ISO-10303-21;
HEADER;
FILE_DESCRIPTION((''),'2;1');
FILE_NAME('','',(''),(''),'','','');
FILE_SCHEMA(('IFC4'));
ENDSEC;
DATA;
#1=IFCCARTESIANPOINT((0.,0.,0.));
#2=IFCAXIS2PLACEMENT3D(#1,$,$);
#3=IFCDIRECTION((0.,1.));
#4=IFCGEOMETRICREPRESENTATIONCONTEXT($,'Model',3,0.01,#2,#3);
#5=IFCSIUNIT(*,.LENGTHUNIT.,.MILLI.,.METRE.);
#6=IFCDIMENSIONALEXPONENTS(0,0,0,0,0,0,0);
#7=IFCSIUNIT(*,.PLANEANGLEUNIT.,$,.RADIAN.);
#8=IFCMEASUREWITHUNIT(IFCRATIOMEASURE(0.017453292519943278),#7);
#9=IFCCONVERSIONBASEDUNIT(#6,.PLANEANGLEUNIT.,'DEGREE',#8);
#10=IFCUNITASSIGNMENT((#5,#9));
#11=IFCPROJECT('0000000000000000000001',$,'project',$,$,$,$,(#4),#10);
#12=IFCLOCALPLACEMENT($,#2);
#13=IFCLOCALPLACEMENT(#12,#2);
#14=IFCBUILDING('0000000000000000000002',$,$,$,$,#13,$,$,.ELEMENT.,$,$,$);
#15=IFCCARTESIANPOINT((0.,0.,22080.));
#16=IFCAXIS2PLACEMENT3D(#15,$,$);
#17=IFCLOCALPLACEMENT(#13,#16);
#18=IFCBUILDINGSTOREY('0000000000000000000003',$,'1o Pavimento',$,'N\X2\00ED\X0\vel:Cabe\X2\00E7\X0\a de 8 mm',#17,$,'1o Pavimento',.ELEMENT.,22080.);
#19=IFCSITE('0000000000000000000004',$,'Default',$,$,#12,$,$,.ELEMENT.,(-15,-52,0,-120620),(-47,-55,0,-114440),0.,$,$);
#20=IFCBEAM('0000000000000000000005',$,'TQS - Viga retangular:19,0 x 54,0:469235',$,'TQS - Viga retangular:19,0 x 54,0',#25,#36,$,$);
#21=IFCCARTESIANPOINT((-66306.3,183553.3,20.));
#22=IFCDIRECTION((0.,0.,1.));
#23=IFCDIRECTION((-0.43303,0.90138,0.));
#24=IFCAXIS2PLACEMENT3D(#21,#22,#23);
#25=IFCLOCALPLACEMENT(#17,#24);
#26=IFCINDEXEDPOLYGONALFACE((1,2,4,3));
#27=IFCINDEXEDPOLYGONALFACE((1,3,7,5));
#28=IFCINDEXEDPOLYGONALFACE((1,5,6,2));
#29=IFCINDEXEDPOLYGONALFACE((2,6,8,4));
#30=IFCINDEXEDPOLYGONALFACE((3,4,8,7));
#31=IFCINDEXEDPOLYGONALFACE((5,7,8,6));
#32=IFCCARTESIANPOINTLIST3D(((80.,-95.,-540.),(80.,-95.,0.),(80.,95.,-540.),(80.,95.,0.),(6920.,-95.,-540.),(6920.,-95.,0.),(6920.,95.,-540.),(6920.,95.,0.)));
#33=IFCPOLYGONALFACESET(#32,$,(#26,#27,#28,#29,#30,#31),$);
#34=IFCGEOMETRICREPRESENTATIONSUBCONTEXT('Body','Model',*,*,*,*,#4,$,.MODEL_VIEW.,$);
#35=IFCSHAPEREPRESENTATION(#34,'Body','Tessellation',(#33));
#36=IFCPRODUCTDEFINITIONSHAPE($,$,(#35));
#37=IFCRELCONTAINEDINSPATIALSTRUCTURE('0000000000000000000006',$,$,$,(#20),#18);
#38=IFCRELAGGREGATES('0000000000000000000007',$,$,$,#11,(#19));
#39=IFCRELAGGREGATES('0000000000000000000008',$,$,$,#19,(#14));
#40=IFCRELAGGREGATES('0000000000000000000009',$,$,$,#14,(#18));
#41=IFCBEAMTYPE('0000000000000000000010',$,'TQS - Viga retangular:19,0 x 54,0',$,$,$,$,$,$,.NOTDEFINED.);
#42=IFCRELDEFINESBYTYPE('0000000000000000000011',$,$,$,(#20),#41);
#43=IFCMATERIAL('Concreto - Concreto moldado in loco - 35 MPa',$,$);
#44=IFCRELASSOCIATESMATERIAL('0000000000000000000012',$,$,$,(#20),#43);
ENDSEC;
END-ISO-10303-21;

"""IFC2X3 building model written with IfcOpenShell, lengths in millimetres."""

from ifc_helpers import new_model, entity, si_unit, converted_unit, direction, frame, frame_2d, origin, place, context, subcontext, project, spatial, rectangle, extrude, material, type_object, element, save


model = new_model("IFC2X3")

# Units and contexts
model_context = context("Model", 3, precision=0.01, world=origin(), true_north=direction((0.0, 1.0)))
body_context = subcontext(model_context, "Body", "Model", "MODEL_VIEW")
ifc_project = project(units=[si_unit("LENGTHUNIT", "METRE", prefix="MILLI"), converted_unit("PLANEANGLEUNIT", "DEGREE", entity("IfcRatioMeasure", 0.017453292519943278), si_unit("PLANEANGLEUNIT", "RADIAN"), dimensions=[0, 0, 0, 0, 0, 0, 0])], contexts=[model_context])

# Site, building, storey
site_placement = place(None, origin())
site = spatial("IfcSite", under=ifc_project, at=site_placement, Name="Default", CompositionType="ELEMENT", RefLatitude=(-15, -52, 0, -120620), RefLongitude=(-47, -55, 0, -114440), RefElevation=0.0)
building_placement = place(site_placement, origin())
building = spatial("IfcBuilding", under=site, at=building_placement, CompositionType="ELEMENT")
storey_placement = place(building_placement, frame((0.0, 0.0, 22080.0)))
storey = spatial("IfcBuildingStorey", under=building, at=storey_placement, Name="1o Pavimento", ObjectType="Nível:Cabeça de 8 mm", LongName="1o Pavimento", CompositionType="ELEMENT", Elevation=22080.0)

# Beam
ifc_material_1 = material(Name="Concreto - Concreto moldado in loco - 35 MPa")
beam_type_1 = type_object("IfcBeamType", Name="TQS - Viga retangular:19,0 x 54,0", PredefinedType="NOTDEFINED")
beam_1_placement = place(storey_placement, frame((-66306.3, 183553.3, 20.0), z_axis=(0.0, 0.0, 1.0), x_axis=(-0.43303, 0.90138, 0.0)))
element("IfcBeam", 1, at=beam_1_placement, inside=storey, type_object=beam_type_1, material=ifc_material_1, Name="TQS - Viga retangular:19,0 x 54,0:469235", ObjectType="TQS - Viga retangular:19,0 x 54,0", context=body_context, shape_type="SweptSolid", body=[
    extrude(rectangle(XDim=540.0, YDim=190.0, at=frame_2d((0.0, 0.0), x_axis=(1.0, 0.0))), frame((80.0, 0.0, -270.0), z_axis=(1.0, 0.0, 0.0), x_axis=(0.0, 0.0, -1.0)), (0.0, 0.0, 1.0), 6840.0),
])

save(model, "model.ifc")
